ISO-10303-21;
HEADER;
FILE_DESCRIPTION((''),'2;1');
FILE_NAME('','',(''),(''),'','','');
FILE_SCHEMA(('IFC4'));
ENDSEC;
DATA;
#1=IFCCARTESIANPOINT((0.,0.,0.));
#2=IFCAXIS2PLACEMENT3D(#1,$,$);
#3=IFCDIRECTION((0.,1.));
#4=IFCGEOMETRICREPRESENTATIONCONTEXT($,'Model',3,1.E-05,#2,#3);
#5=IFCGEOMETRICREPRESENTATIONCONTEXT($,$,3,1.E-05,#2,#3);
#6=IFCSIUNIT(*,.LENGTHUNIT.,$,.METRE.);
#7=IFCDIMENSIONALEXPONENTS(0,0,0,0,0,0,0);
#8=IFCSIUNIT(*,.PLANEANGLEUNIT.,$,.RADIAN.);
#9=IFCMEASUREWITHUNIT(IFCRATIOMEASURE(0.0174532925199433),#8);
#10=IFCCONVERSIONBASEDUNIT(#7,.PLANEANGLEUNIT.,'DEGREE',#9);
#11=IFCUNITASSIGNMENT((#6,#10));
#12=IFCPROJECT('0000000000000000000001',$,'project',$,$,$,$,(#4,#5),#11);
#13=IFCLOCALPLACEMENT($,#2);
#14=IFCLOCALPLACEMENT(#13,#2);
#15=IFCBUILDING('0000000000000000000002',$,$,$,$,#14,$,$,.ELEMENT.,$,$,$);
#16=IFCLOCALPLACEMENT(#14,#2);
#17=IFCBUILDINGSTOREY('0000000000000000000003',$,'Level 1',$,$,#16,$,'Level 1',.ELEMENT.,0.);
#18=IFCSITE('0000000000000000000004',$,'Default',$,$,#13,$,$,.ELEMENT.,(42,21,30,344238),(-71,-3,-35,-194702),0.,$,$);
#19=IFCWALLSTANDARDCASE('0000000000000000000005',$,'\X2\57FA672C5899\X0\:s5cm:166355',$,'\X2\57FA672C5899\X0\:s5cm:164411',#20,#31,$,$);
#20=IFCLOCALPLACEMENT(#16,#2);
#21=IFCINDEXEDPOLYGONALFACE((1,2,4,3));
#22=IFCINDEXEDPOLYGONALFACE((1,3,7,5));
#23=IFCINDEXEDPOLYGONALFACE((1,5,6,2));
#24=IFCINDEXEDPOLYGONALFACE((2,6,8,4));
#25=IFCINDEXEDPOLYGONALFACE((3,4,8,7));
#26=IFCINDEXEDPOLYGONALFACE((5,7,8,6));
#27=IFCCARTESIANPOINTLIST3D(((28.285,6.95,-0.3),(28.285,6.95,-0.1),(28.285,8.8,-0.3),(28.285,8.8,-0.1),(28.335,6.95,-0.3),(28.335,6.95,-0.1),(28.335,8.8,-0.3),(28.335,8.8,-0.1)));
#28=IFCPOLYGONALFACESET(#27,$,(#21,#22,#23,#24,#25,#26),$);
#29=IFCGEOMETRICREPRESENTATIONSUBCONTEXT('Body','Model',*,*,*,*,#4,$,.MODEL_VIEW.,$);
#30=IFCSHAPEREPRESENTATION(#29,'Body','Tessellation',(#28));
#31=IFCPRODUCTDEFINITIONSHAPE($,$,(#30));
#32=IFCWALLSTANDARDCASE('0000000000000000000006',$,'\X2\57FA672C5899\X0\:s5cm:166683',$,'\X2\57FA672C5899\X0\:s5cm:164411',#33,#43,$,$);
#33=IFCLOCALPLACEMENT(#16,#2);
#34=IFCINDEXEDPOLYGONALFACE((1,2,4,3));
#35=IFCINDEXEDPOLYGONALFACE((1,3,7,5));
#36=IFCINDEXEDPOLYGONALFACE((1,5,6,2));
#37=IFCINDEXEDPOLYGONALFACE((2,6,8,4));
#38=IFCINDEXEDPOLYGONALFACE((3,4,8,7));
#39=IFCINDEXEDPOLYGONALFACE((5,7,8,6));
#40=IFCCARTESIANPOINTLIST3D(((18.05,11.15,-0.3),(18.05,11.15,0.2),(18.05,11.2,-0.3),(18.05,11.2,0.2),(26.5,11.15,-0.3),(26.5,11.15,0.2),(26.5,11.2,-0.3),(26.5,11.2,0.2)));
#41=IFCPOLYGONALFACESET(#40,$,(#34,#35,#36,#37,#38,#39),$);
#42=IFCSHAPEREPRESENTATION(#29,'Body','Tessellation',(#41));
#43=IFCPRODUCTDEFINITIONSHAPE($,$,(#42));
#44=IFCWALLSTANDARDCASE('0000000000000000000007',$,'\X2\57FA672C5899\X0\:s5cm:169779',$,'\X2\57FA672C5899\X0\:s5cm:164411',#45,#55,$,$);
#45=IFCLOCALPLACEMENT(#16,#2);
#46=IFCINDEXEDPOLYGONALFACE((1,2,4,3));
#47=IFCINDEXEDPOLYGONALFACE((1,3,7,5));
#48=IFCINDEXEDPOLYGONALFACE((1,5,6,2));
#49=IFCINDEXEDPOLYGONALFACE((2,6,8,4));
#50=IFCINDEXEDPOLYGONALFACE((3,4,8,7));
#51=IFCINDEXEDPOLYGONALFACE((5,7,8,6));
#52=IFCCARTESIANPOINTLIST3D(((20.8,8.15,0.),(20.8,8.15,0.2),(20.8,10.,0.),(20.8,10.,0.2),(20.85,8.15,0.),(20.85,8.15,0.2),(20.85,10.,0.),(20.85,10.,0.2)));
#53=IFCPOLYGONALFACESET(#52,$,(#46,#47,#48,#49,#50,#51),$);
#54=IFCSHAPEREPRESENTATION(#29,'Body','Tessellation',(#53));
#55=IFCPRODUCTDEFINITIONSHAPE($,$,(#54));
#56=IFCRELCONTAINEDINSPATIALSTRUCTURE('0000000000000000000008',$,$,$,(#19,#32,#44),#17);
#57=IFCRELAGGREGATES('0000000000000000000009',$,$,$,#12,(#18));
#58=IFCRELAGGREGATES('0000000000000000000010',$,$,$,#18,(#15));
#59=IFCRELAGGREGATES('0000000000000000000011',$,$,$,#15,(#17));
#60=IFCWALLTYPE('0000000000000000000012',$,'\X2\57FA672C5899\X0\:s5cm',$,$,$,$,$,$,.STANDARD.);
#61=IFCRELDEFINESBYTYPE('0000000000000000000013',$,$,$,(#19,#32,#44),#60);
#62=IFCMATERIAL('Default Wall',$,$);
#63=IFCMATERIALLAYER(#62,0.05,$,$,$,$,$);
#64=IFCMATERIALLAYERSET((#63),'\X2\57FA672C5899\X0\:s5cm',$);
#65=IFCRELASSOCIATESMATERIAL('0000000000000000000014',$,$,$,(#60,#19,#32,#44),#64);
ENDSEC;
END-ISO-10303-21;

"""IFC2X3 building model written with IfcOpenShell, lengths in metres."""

from ifc_helpers import new_model, entity, si_unit, converted_unit, direction, frame, frame_2d, origin, place, context, subcontext, project, spatial, rectangle, extrude, material, layer, layer_set, layer_usage, type_object, element, save


model = new_model("IFC2X3")

# Units and contexts
model_context = context("Model", 3, precision=1e-05, world=origin(), true_north=direction((0.0, 1.0)))
context_of_model = context(None, 3, precision=1e-05, world=origin(), true_north=direction((0.0, 1.0)))
body_context = subcontext(model_context, "Body", "Model", "MODEL_VIEW")
ifc_project = project(units=[si_unit("LENGTHUNIT", "METRE"), converted_unit("PLANEANGLEUNIT", "DEGREE", entity("IfcRatioMeasure", 0.0174532925199433), si_unit("PLANEANGLEUNIT", "RADIAN"), dimensions=[0, 0, 0, 0, 0, 0, 0])], contexts=[model_context, context_of_model])

# Site, building, storey
site_placement = place(None, origin())
site = spatial("IfcSite", under=ifc_project, at=site_placement, Name="Default", CompositionType="ELEMENT", RefLatitude=(42, 21, 30, 344238), RefLongitude=(-71, -3, -35, -194702), RefElevation=0.0)
building_placement = place(site_placement, origin())
building = spatial("IfcBuilding", under=site, at=building_placement, CompositionType="ELEMENT")
storey_placement = place(building_placement, origin())
storey = spatial("IfcBuildingStorey", under=building, at=storey_placement, Name="Level 1", LongName="Level 1", CompositionType="ELEMENT", Elevation=0.0)

# Shared definitions
ifc_material = material(Name="Default Wall")

# Walls
ifc_layer_1 = layer(ifc_material, 0.05)
ifc_layer_set_1 = layer_set([ifc_layer_1], Name="基本墙:s5cm")
wall_type_1 = type_object("IfcWallType", Name="基本墙:s5cm", PredefinedType="STANDARD", material=ifc_layer_set_1)
ifc_layer_usage_1 = layer_usage(ifc_layer_set_1, "AXIS2", "POSITIVE", -0.025)
wall_1_placement = place(storey_placement, frame((28.31, 6.95, -0.3), z_axis=(0.0, 0.0, 1.0), x_axis=(0.0, 1.0, 0.0)))
element("IfcWallStandardCase", 1, at=wall_1_placement, inside=storey, type_object=wall_type_1, material=ifc_layer_usage_1, Name="基本墙:s5cm:166355", ObjectType="基本墙:s5cm:164411", context=body_context, shape_type="SweptSolid", body=[
    extrude(rectangle(XDim=1.85, YDim=0.05, at=frame_2d((0.925, 0.0), x_axis=(-1.0, 0.0))), origin(), (0.0, 0.0, 1.0), 0.2),
])
ifc_layer_usage_2 = layer_usage(ifc_layer_set_1, "AXIS2", "NEGATIVE", 0.025)
wall_2_placement = place(storey_placement, frame((26.5, 11.175, -0.3), z_axis=(0.0, 0.0, 1.0), x_axis=(-1.0, 0.0, 0.0)))
element("IfcWallStandardCase", 2, at=wall_2_placement, inside=storey, type_object=wall_type_1, material=ifc_layer_usage_2, Name="基本墙:s5cm:166683", ObjectType="基本墙:s5cm:164411", context=body_context, shape_type="SweptSolid", body=[
    extrude(rectangle(XDim=8.45, YDim=0.05, at=frame_2d((4.225, 0.0), x_axis=(-1.0, 0.0))), origin(), (0.0, 0.0, 1.0), 0.5),
])
ifc_layer_usage_3 = layer_usage(ifc_layer_set_1, "AXIS2", "NEGATIVE", 0.025)
wall_3_placement = place(storey_placement, frame((20.825, 10.0, 0.0), z_axis=(0.0, 0.0, 1.0), x_axis=(0.0, -1.0, 0.0)))
element("IfcWallStandardCase", 3, at=wall_3_placement, inside=storey, type_object=wall_type_1, material=ifc_layer_usage_3, Name="基本墙:s5cm:169779", ObjectType="基本墙:s5cm:164411", context=body_context, shape_type="SweptSolid", body=[
    extrude(rectangle(XDim=1.85, YDim=0.05, at=frame_2d((0.925, 0.0), x_axis=(-1.0, 0.0))), origin(), (0.0, 0.0, 1.0), 0.2),
])

save(model, "model.ifc")
